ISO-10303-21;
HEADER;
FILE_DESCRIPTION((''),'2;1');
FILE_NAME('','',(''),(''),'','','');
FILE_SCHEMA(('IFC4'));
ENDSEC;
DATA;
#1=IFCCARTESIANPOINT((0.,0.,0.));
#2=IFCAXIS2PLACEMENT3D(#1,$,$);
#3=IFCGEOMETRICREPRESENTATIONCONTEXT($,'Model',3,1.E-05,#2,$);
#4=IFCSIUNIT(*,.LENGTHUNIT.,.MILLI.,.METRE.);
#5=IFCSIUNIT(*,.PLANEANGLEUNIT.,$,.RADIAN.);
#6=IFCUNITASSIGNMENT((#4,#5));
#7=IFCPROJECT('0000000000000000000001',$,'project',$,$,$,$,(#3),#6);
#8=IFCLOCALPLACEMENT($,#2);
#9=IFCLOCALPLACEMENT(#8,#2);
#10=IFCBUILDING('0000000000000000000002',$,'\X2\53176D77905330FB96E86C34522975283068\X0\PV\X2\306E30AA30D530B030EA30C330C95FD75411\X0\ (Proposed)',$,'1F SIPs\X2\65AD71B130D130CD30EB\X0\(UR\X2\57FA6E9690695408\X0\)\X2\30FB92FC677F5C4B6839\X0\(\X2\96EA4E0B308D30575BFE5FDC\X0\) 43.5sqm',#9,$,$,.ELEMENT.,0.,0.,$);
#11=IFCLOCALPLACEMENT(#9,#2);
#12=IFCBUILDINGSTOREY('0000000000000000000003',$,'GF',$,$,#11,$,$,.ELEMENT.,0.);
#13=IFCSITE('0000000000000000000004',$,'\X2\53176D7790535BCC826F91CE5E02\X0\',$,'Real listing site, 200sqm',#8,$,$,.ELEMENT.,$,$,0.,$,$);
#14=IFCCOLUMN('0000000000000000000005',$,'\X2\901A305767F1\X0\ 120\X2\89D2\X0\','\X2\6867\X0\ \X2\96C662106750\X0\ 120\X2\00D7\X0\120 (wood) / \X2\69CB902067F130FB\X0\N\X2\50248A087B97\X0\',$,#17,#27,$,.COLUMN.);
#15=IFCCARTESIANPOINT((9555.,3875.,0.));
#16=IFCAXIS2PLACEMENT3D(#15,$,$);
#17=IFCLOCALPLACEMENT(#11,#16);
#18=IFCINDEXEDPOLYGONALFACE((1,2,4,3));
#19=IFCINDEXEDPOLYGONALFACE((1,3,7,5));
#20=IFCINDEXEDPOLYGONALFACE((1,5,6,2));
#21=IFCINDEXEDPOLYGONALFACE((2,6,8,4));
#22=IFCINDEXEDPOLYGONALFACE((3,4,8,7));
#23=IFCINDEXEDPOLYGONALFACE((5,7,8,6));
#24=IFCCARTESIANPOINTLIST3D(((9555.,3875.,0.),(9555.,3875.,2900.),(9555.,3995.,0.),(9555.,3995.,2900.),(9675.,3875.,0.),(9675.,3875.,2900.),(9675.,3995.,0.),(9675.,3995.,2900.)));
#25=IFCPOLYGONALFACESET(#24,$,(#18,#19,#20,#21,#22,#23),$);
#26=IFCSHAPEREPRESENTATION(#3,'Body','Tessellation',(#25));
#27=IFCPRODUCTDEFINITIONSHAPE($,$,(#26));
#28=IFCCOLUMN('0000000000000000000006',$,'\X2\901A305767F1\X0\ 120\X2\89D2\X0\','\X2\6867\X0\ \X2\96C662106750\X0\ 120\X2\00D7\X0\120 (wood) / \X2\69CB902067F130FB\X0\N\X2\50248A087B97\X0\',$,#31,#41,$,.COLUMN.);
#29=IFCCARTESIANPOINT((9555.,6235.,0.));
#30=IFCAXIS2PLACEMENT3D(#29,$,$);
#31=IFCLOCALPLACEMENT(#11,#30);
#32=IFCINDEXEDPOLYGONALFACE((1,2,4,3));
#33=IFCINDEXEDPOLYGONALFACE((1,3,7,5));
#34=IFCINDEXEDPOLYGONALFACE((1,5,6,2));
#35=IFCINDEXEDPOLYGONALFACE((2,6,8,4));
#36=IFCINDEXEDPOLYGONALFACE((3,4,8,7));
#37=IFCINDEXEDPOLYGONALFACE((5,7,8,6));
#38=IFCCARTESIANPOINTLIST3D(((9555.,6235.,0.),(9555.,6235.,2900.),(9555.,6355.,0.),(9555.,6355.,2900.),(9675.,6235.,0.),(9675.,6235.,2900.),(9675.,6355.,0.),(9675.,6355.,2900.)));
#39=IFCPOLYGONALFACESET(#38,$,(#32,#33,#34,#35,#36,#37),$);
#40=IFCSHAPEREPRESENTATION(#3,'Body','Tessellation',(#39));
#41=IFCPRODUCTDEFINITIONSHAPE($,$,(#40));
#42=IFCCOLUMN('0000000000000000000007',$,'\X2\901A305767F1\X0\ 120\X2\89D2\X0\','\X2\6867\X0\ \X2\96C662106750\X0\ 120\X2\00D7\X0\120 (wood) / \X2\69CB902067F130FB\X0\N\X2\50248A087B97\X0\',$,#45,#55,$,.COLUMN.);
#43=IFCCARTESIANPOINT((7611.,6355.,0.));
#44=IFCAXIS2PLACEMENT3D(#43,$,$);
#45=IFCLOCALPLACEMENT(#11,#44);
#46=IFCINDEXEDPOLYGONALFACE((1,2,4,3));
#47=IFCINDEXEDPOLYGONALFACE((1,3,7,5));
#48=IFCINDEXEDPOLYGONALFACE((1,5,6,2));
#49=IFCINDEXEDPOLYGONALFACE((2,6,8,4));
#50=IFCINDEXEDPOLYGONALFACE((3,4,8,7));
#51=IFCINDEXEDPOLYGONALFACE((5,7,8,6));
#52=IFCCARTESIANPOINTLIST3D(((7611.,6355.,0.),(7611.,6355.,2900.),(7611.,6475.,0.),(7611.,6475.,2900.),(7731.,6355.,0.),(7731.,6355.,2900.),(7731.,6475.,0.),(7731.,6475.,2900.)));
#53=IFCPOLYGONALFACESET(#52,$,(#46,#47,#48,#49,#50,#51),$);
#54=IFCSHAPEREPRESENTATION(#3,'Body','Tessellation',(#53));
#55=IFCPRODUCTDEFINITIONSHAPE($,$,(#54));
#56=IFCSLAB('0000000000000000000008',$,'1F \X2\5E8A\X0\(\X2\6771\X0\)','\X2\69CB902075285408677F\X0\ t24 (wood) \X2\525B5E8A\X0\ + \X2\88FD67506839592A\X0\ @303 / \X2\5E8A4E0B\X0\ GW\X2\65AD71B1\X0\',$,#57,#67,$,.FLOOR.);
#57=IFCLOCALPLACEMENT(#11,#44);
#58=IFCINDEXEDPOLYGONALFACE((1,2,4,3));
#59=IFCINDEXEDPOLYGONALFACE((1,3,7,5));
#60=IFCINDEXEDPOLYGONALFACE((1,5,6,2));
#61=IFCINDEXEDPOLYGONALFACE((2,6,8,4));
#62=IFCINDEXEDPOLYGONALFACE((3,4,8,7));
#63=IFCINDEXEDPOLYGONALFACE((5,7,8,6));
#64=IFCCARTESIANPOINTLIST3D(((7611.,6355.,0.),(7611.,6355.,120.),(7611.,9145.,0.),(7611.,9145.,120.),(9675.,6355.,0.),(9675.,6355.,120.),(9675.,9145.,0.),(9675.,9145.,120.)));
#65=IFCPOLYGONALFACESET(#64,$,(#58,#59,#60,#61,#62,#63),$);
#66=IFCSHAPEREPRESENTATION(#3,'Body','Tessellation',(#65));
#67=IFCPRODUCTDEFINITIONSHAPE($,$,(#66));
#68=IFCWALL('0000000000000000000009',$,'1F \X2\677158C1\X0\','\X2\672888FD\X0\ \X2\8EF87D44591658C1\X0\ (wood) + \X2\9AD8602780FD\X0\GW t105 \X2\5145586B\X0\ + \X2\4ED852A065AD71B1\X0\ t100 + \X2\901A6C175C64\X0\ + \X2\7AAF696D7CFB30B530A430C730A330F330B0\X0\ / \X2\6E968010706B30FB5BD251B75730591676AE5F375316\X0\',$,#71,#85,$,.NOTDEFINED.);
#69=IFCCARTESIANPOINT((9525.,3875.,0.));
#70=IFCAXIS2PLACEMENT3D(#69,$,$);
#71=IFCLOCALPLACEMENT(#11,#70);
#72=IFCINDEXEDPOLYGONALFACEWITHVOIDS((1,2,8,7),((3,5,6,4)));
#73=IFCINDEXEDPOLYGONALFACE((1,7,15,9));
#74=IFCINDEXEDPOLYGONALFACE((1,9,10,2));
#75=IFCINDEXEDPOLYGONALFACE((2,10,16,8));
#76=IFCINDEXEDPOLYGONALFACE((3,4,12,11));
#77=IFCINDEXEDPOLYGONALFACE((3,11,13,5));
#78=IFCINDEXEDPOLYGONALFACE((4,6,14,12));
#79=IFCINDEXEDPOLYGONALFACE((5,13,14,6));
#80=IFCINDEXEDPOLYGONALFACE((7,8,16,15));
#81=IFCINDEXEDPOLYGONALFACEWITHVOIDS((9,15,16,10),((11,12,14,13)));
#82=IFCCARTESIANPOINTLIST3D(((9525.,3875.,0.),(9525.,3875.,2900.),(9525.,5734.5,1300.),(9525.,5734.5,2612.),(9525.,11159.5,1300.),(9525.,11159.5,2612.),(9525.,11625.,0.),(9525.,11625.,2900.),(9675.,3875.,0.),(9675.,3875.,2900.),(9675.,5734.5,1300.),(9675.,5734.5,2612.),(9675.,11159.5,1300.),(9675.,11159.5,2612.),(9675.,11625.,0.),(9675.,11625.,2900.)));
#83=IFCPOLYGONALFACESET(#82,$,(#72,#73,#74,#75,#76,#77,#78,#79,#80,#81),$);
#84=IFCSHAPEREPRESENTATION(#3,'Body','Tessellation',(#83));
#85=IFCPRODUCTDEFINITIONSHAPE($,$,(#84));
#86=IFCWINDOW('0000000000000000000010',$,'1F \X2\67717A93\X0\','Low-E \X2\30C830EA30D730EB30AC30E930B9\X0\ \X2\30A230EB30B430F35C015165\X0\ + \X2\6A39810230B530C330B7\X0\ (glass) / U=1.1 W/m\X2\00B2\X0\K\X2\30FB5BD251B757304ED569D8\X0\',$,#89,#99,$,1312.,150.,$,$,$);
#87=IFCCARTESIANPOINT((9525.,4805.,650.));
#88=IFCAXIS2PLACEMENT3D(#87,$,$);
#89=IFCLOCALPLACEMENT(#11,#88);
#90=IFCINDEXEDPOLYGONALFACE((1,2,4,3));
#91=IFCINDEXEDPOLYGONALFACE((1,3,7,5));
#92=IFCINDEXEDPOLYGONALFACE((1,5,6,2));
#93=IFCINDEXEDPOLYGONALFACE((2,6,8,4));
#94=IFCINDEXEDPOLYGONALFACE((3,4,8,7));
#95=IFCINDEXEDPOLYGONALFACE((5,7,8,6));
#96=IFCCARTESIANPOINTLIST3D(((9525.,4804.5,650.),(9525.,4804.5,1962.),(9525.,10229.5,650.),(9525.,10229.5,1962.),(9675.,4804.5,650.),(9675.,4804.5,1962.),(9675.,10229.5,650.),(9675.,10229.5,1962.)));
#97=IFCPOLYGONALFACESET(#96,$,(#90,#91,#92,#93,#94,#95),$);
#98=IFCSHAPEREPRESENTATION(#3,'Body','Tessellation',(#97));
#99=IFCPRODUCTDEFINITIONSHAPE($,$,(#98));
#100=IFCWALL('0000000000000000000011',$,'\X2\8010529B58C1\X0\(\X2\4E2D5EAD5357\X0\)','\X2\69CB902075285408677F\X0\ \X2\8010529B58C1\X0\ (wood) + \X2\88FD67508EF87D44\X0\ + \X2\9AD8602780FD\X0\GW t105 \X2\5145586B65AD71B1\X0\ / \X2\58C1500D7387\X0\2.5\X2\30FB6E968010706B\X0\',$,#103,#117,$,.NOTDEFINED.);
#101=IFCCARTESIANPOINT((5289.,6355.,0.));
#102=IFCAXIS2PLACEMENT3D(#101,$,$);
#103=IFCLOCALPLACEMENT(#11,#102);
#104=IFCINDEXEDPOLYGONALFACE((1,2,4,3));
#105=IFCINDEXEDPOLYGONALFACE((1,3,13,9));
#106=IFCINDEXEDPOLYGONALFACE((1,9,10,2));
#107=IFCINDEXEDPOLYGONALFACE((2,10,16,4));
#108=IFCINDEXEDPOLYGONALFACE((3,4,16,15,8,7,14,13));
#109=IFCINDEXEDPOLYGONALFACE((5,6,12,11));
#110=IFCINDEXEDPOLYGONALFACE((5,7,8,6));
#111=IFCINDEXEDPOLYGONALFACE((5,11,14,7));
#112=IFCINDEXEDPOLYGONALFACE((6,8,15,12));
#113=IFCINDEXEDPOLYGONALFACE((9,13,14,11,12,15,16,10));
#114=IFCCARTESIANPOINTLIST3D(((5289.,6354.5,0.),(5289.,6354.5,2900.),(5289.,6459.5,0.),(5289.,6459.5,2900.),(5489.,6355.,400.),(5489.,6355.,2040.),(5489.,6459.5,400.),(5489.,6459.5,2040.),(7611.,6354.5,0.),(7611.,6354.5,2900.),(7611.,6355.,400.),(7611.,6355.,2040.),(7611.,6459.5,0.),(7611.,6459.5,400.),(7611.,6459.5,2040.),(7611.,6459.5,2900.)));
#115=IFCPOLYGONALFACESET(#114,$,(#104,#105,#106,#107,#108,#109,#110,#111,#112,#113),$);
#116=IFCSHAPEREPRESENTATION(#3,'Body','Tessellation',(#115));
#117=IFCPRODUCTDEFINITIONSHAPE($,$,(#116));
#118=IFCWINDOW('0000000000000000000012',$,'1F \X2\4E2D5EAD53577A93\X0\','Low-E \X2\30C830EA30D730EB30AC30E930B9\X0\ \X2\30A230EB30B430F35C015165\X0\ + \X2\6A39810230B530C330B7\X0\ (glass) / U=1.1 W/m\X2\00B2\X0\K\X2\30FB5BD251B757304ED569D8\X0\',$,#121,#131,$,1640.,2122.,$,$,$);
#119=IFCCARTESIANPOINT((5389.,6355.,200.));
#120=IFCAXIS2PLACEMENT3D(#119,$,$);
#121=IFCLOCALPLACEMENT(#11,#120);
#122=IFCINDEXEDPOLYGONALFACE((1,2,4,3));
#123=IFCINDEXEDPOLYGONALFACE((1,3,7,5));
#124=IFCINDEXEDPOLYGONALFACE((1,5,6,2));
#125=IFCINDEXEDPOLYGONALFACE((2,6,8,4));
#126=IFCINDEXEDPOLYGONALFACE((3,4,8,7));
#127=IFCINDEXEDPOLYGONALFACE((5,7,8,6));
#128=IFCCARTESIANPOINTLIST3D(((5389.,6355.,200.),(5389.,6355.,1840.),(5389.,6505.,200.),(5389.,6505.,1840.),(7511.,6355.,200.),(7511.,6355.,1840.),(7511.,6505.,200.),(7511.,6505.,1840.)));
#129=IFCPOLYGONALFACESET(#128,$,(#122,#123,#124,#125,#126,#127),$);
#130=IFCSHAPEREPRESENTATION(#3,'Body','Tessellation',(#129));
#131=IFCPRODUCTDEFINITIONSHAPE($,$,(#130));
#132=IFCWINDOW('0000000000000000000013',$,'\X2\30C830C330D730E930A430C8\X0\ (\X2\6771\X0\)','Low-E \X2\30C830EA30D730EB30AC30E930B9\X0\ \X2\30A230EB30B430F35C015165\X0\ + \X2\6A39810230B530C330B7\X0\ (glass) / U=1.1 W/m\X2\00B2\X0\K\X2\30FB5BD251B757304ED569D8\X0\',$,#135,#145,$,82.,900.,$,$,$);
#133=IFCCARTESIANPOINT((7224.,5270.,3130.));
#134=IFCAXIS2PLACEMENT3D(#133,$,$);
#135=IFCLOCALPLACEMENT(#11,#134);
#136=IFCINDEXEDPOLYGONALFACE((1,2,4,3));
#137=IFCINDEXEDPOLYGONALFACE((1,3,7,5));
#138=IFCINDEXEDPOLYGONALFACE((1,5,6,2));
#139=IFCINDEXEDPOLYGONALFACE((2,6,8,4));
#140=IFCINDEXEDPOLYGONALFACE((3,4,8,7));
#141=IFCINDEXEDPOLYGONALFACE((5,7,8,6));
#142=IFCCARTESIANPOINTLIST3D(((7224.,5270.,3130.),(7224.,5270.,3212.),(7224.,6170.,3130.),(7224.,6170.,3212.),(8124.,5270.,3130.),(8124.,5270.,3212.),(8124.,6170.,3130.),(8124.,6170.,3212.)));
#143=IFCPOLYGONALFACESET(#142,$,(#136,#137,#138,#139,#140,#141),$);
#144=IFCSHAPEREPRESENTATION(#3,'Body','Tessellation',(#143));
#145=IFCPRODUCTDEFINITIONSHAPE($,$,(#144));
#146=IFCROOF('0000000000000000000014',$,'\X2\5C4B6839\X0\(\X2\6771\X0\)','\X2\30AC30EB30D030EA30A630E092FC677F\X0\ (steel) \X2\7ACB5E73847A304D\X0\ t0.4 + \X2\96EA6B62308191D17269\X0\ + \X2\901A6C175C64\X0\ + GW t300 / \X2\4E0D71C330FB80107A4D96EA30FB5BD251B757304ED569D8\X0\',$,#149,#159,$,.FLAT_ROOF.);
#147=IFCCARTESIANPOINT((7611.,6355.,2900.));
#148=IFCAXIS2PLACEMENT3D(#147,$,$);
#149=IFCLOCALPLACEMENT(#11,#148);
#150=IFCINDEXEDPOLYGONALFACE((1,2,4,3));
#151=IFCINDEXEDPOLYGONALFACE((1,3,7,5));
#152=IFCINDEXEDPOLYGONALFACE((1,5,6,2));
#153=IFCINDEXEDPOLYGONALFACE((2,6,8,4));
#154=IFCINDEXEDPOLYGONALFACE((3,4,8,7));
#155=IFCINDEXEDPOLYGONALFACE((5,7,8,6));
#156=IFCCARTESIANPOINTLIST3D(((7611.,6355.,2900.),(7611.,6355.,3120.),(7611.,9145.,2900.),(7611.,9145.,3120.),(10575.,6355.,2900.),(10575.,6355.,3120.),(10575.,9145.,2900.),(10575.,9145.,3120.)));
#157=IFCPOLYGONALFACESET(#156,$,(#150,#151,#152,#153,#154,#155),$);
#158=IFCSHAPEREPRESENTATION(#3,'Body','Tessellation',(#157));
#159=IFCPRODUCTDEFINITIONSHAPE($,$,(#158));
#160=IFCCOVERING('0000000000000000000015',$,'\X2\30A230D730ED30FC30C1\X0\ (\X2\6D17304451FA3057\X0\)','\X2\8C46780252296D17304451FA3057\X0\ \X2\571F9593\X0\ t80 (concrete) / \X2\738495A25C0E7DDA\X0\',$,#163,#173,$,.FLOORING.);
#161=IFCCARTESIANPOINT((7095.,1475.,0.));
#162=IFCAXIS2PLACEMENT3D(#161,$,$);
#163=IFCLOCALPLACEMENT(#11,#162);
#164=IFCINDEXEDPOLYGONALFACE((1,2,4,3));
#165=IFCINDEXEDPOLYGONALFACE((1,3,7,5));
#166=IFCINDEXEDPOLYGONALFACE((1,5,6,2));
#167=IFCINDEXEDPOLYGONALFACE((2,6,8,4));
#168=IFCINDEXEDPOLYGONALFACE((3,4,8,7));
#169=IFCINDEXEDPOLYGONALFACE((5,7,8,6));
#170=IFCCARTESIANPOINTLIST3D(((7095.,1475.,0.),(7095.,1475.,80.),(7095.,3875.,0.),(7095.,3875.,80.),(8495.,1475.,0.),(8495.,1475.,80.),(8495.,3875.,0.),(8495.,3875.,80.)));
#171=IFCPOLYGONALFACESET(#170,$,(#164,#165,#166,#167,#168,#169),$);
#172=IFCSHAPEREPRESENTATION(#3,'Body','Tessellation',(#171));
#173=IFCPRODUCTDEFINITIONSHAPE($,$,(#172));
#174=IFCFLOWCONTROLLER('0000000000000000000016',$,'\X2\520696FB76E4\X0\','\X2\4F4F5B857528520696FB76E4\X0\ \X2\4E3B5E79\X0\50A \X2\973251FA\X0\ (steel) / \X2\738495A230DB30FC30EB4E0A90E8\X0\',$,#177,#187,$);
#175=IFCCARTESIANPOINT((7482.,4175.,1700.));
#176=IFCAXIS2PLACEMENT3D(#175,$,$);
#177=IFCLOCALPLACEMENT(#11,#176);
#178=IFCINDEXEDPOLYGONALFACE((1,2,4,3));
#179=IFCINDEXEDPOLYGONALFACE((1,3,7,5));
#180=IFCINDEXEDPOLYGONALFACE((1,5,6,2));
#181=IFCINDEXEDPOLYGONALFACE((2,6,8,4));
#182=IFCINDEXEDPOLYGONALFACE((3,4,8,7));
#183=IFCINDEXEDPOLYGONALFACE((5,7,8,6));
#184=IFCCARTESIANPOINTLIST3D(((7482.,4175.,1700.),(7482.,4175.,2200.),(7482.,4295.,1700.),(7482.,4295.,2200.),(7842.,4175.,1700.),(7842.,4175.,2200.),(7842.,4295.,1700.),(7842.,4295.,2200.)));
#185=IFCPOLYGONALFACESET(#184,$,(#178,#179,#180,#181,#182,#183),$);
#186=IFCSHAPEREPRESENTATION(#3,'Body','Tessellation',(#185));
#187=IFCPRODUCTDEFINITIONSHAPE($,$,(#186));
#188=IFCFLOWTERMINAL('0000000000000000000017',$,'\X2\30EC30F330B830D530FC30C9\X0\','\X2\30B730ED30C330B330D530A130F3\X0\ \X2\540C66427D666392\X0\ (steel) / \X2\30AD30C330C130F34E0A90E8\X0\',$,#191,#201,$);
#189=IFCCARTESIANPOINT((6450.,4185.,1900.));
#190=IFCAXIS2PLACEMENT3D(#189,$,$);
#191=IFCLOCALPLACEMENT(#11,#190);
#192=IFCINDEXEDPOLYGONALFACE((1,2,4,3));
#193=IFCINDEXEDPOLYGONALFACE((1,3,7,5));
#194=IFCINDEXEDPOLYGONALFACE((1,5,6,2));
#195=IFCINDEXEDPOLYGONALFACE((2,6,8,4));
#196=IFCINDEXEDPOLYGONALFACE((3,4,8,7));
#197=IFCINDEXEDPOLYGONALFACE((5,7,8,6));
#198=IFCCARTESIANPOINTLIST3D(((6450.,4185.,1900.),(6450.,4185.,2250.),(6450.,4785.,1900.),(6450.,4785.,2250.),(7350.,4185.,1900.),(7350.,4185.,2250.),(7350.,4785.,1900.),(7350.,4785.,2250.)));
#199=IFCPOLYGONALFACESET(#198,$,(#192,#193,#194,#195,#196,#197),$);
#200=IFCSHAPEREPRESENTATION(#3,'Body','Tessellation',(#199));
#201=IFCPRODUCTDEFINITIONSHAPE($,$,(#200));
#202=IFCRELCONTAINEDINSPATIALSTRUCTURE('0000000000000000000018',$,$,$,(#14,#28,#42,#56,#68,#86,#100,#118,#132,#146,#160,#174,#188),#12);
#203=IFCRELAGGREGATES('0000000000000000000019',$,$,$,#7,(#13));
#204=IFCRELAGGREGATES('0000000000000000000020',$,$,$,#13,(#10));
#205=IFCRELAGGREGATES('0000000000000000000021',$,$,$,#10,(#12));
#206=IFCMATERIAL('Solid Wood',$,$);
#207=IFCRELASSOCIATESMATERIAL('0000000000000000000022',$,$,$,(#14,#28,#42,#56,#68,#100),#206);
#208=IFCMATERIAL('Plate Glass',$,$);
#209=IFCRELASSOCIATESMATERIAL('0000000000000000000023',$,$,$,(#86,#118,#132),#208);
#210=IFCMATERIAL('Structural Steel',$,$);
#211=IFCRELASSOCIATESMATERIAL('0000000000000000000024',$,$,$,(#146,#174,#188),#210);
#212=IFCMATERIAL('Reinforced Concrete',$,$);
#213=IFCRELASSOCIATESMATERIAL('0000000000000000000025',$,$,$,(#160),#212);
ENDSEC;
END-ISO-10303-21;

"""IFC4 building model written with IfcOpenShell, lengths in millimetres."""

from ifc_helpers import new_model, si_unit, frame, frame_2d, origin, place, context, project, spatial, rectangle, extrude, material, element, fill, save


model = new_model("IFC4")

# Units and contexts
model_context = context("Model", 3, precision=1e-05, world=origin())
ifc_project = project(units=[si_unit("LENGTHUNIT", "METRE", prefix="MILLI"), si_unit("PLANEANGLEUNIT", "RADIAN")], contexts=[model_context])

# Site, building, storey
site_placement = place(None, origin())
site = spatial("IfcSite", under=ifc_project, at=site_placement, Name="北海道富良野市", ObjectType="Real listing site, 200sqm", CompositionType="ELEMENT", RefElevation=0.0)
building_placement = place(site_placement, origin())
building = spatial("IfcBuilding", under=site, at=building_placement, Name="北海道・雨水利用とPVのオフグリッド志向 (Proposed)", ObjectType="1F SIPs断熱パネル(UR基準適合)・鋼板屋根(雪下ろし対応) 43.5sqm", CompositionType="ELEMENT", ElevationOfRefHeight=0.0, ElevationOfTerrain=0.0)
storey_placement = place(building_placement, origin())
storey = spatial("IfcBuildingStorey", under=building, at=storey_placement, Name="GF", CompositionType="ELEMENT", Elevation=0.0)

# Columns
ifc_material_1 = material(Name="Solid Wood")
column_1_placement = place(storey_placement, frame((9555.0, 3875.0, 0.0)))
element("IfcColumn", 1, at=column_1_placement, inside=storey, material=ifc_material_1, Name="通し柱 120角", Description="桧 集成材 120×120 (wood) / 構造柱・N値計算", PredefinedType="COLUMN", context=model_context, shape_type="SweptSolid", body=[
    extrude(rectangle(XDim=120.0, YDim=120.0, at=frame_2d((60.0, 60.0))), frame((9555.0, 3875.0, 0.0)), (0.0, 0.0, 1.0), 2900.0),
])
column_2_placement = place(storey_placement, frame((9555.0, 6235.0, 0.0)))
element("IfcColumn", 2, at=column_2_placement, inside=storey, material=ifc_material_1, Name="通し柱 120角", Description="桧 集成材 120×120 (wood) / 構造柱・N値計算", PredefinedType="COLUMN", context=model_context, shape_type="SweptSolid", body=[
    extrude(rectangle(XDim=120.0, YDim=120.0, at=frame_2d((60.0, 60.0))), frame((9555.0, 6235.0, 0.0)), (0.0, 0.0, 1.0), 2900.0),
])
column_3_placement = place(storey_placement, frame((7611.0, 6355.0, 0.0)))
element("IfcColumn", 3, at=column_3_placement, inside=storey, material=ifc_material_1, Name="通し柱 120角", Description="桧 集成材 120×120 (wood) / 構造柱・N値計算", PredefinedType="COLUMN", context=model_context, shape_type="SweptSolid", body=[
    extrude(rectangle(XDim=120.0, YDim=120.0, at=frame_2d((60.0, 60.0))), frame((7611.0, 6355.0, 0.0)), (0.0, 0.0, 1.0), 2900.0),
])

# Slab
slab_placement = place(storey_placement, frame((7611.0, 6355.0, 0.0)))
element("IfcSlab", 4, at=slab_placement, inside=storey, material=ifc_material_1, Name="1F 床(東)", Description="構造用合板 t24 (wood) 剛床 + 製材根太 @303 / 床下 GW断熱", PredefinedType="FLOOR", context=model_context, shape_type="SweptSolid", body=[
    extrude(rectangle(XDim=2064.0, YDim=2790.0, at=frame_2d((1032.0, 1395.0))), frame((7611.0, 6355.0, 0.0)), (0.0, 0.0, 1.0), 120.0),
])

# Walls, openings, windows
wall_1_placement = place(storey_placement, frame((9525.0, 3875.0, 0.0)))
wall_1 = element("IfcWall", 5, at=wall_1_placement, inside=storey, material=ifc_material_1, Name="1F 東壁", Description="木製 軸組外壁 (wood) + 高性能GW t105 充填 + 付加断熱 t100 + 通気層 + 窯業系サイディング / 準耐火・寒冷地外皮強化", PredefinedType="NOTDEFINED", context=model_context, shape_type="SweptSolid", body=[
    extrude(rectangle(XDim=150.0, YDim=7750.0, at=frame_2d((75.0, 3875.0))), frame((9525.0, 3875.0, 0.0)), (0.0, 0.0, 1.0), 2900.0),
])
opening_1_placement = place(storey_placement, frame((9525.0, 4805.0, 650.0)))
opening_1 = element("IfcOpeningElement", 6, at=opening_1_placement, cuts=wall_1, PredefinedType="NOTDEFINED", context=model_context, shape_type="SweptSolid", body=[
    extrude(rectangle(XDim=150.0, YDim=5425.0, at=frame_2d((75.0, 2712.0))), frame((9525.0, 4805.0, 650.0)), (0.0, 0.0, 1.0), 1312.0),
])
ifc_material_2 = material(Name="Plate Glass")
window_1_placement = place(storey_placement, frame((9525.0, 4805.0, 650.0)))
window_1 = element("IfcWindow", 7, at=window_1_placement, inside=storey, material=ifc_material_2, Name="1F 東窓", Description="Low-E トリプルガラス アルゴン封入 + 樹脂サッシ (glass) / U=1.1 W/m²K・寒冷地仕様", OverallHeight=1312.0, OverallWidth=150.0, context=model_context, shape_type="SweptSolid", body=[
    extrude(rectangle(XDim=150.0, YDim=5425.0, at=frame_2d((75.0, 2712.0))), frame((9525.0, 4805.0, 650.0)), (0.0, 0.0, 1.0), 1312.0),
])
fill(opening_1, window_1)
wall_2_placement = place(storey_placement, frame((5289.0, 6355.0, 0.0)))
wall_2 = element("IfcWall", 8, at=wall_2_placement, inside=storey, material=ifc_material_1, Name="耐力壁(中庭南)", Description="構造用合板 耐力壁 (wood) + 製材軸組 + 高性能GW t105 充填断熱 / 壁倍率2.5・準耐火", PredefinedType="NOTDEFINED", context=model_context, shape_type="SweptSolid", body=[
    extrude(rectangle(XDim=2322.0, YDim=105.0, at=frame_2d((1161.0, 52.0))), frame((5289.0, 6355.0, 0.0)), (0.0, 0.0, 1.0), 2900.0),
])
opening_2_placement = place(storey_placement, frame((5389.0, 6355.0, 200.0)))
opening_2 = element("IfcOpeningElement", 9, at=opening_2_placement, cuts=wall_2, PredefinedType="NOTDEFINED", context=model_context, shape_type="SweptSolid", body=[
    extrude(rectangle(XDim=2122.0, YDim=150.0, at=frame_2d((1061.0, 75.0))), frame((5389.0, 6355.0, 200.0)), (0.0, 0.0, 1.0), 1640.0),
])
window_2_placement = place(storey_placement, frame((5389.0, 6355.0, 200.0)))
window_2 = element("IfcWindow", 10, at=window_2_placement, inside=storey, material=ifc_material_2, Name="1F 中庭南窓", Description="Low-E トリプルガラス アルゴン封入 + 樹脂サッシ (glass) / U=1.1 W/m²K・寒冷地仕様", OverallHeight=1640.0, OverallWidth=2122.0, context=model_context, shape_type="SweptSolid", body=[
    extrude(rectangle(XDim=2122.0, YDim=150.0, at=frame_2d((1061.0, 75.0))), frame((5389.0, 6355.0, 200.0)), (0.0, 0.0, 1.0), 1640.0),
])
fill(opening_2, window_2)

# Window
window_3_placement = place(storey_placement, frame((7224.0, 5270.0, 3130.0)))
element("IfcWindow", 11, at=window_3_placement, inside=storey, material=ifc_material_2, Name="トップライト (東)", Description="Low-E トリプルガラス アルゴン封入 + 樹脂サッシ (glass) / U=1.1 W/m²K・寒冷地仕様", OverallHeight=82.0, OverallWidth=900.0, context=model_context, shape_type="SweptSolid", body=[
    extrude(rectangle(XDim=900.0, YDim=900.0, at=frame_2d((450.0, 450.0))), frame((7224.0, 5270.0, 3130.0)), (0.0, 0.0, 1.0), 82.0),
])

# Roof
ifc_material_3 = material(Name="Structural Steel")
roof_placement = place(storey_placement, frame((7611.0, 6355.0, 2900.0)))
element("IfcRoof", 12, at=roof_placement, inside=storey, material=ifc_material_3, Name="屋根(東)", Description="ガルバリウム鋼板 (steel) 立平葺き t0.4 + 雪止め金物 + 通気層 + GW t300 / 不燃・耐積雪・寒冷地仕様", PredefinedType="FLAT_ROOF", context=model_context, shape_type="SweptSolid", body=[
    extrude(rectangle(XDim=2964.0, YDim=2790.0, at=frame_2d((1482.0, 1395.0))), frame((7611.0, 6355.0, 2900.0)), (0.0, 0.0, 1.0), 220.0),
])

# Covering
ifc_material_4 = material(Name="Reinforced Concrete")
covering_placement = place(storey_placement, frame((7095.0, 1475.0, 0.0)))
element("IfcCovering", 13, at=covering_placement, inside=storey, material=ifc_material_4, Name="アプローチ (洗い出し)", Description="豆砂利洗い出し 土間 t80 (concrete) / 玄関導線", PredefinedType="FLOORING", context=model_context, shape_type="SweptSolid", body=[
    extrude(rectangle(XDim=1400.0, YDim=2400.0, at=frame_2d((700.0, 1200.0))), frame((7095.0, 1475.0, 0.0)), (0.0, 0.0, 1.0), 80.0),
])

# Flow controller
flow_controller_placement = place(storey_placement, frame((7482.0, 4175.0, 1700.0)))
element("IfcFlowController", 14, at=flow_controller_placement, inside=storey, material=ifc_material_3, Name="分電盤", Description="住宅用分電盤 主幹50A 露出 (steel) / 玄関ホール上部", context=model_context, shape_type="SweptSolid", body=[
    extrude(rectangle(XDim=360.0, YDim=120.0, at=frame_2d((180.0, 60.0))), frame((7482.0, 4175.0, 1700.0)), (0.0, 0.0, 1.0), 500.0),
])

# Flow terminal
flow_terminal_1_placement = place(storey_placement, frame((6450.0, 4185.0, 1900.0)))
element("IfcFlowTerminal", 15, at=flow_terminal_1_placement, inside=storey, material=ifc_material_3, Name="レンジフード", Description="シロッコファン 同時給排 (steel) / キッチン上部", context=model_context, shape_type="SweptSolid", body=[
    extrude(rectangle(XDim=900.0, YDim=600.0, at=frame_2d((450.0, 300.0))), frame((6450.0, 4185.0, 1900.0)), (0.0, 0.0, 1.0), 350.0),
])

save(model, "model.ifc")
